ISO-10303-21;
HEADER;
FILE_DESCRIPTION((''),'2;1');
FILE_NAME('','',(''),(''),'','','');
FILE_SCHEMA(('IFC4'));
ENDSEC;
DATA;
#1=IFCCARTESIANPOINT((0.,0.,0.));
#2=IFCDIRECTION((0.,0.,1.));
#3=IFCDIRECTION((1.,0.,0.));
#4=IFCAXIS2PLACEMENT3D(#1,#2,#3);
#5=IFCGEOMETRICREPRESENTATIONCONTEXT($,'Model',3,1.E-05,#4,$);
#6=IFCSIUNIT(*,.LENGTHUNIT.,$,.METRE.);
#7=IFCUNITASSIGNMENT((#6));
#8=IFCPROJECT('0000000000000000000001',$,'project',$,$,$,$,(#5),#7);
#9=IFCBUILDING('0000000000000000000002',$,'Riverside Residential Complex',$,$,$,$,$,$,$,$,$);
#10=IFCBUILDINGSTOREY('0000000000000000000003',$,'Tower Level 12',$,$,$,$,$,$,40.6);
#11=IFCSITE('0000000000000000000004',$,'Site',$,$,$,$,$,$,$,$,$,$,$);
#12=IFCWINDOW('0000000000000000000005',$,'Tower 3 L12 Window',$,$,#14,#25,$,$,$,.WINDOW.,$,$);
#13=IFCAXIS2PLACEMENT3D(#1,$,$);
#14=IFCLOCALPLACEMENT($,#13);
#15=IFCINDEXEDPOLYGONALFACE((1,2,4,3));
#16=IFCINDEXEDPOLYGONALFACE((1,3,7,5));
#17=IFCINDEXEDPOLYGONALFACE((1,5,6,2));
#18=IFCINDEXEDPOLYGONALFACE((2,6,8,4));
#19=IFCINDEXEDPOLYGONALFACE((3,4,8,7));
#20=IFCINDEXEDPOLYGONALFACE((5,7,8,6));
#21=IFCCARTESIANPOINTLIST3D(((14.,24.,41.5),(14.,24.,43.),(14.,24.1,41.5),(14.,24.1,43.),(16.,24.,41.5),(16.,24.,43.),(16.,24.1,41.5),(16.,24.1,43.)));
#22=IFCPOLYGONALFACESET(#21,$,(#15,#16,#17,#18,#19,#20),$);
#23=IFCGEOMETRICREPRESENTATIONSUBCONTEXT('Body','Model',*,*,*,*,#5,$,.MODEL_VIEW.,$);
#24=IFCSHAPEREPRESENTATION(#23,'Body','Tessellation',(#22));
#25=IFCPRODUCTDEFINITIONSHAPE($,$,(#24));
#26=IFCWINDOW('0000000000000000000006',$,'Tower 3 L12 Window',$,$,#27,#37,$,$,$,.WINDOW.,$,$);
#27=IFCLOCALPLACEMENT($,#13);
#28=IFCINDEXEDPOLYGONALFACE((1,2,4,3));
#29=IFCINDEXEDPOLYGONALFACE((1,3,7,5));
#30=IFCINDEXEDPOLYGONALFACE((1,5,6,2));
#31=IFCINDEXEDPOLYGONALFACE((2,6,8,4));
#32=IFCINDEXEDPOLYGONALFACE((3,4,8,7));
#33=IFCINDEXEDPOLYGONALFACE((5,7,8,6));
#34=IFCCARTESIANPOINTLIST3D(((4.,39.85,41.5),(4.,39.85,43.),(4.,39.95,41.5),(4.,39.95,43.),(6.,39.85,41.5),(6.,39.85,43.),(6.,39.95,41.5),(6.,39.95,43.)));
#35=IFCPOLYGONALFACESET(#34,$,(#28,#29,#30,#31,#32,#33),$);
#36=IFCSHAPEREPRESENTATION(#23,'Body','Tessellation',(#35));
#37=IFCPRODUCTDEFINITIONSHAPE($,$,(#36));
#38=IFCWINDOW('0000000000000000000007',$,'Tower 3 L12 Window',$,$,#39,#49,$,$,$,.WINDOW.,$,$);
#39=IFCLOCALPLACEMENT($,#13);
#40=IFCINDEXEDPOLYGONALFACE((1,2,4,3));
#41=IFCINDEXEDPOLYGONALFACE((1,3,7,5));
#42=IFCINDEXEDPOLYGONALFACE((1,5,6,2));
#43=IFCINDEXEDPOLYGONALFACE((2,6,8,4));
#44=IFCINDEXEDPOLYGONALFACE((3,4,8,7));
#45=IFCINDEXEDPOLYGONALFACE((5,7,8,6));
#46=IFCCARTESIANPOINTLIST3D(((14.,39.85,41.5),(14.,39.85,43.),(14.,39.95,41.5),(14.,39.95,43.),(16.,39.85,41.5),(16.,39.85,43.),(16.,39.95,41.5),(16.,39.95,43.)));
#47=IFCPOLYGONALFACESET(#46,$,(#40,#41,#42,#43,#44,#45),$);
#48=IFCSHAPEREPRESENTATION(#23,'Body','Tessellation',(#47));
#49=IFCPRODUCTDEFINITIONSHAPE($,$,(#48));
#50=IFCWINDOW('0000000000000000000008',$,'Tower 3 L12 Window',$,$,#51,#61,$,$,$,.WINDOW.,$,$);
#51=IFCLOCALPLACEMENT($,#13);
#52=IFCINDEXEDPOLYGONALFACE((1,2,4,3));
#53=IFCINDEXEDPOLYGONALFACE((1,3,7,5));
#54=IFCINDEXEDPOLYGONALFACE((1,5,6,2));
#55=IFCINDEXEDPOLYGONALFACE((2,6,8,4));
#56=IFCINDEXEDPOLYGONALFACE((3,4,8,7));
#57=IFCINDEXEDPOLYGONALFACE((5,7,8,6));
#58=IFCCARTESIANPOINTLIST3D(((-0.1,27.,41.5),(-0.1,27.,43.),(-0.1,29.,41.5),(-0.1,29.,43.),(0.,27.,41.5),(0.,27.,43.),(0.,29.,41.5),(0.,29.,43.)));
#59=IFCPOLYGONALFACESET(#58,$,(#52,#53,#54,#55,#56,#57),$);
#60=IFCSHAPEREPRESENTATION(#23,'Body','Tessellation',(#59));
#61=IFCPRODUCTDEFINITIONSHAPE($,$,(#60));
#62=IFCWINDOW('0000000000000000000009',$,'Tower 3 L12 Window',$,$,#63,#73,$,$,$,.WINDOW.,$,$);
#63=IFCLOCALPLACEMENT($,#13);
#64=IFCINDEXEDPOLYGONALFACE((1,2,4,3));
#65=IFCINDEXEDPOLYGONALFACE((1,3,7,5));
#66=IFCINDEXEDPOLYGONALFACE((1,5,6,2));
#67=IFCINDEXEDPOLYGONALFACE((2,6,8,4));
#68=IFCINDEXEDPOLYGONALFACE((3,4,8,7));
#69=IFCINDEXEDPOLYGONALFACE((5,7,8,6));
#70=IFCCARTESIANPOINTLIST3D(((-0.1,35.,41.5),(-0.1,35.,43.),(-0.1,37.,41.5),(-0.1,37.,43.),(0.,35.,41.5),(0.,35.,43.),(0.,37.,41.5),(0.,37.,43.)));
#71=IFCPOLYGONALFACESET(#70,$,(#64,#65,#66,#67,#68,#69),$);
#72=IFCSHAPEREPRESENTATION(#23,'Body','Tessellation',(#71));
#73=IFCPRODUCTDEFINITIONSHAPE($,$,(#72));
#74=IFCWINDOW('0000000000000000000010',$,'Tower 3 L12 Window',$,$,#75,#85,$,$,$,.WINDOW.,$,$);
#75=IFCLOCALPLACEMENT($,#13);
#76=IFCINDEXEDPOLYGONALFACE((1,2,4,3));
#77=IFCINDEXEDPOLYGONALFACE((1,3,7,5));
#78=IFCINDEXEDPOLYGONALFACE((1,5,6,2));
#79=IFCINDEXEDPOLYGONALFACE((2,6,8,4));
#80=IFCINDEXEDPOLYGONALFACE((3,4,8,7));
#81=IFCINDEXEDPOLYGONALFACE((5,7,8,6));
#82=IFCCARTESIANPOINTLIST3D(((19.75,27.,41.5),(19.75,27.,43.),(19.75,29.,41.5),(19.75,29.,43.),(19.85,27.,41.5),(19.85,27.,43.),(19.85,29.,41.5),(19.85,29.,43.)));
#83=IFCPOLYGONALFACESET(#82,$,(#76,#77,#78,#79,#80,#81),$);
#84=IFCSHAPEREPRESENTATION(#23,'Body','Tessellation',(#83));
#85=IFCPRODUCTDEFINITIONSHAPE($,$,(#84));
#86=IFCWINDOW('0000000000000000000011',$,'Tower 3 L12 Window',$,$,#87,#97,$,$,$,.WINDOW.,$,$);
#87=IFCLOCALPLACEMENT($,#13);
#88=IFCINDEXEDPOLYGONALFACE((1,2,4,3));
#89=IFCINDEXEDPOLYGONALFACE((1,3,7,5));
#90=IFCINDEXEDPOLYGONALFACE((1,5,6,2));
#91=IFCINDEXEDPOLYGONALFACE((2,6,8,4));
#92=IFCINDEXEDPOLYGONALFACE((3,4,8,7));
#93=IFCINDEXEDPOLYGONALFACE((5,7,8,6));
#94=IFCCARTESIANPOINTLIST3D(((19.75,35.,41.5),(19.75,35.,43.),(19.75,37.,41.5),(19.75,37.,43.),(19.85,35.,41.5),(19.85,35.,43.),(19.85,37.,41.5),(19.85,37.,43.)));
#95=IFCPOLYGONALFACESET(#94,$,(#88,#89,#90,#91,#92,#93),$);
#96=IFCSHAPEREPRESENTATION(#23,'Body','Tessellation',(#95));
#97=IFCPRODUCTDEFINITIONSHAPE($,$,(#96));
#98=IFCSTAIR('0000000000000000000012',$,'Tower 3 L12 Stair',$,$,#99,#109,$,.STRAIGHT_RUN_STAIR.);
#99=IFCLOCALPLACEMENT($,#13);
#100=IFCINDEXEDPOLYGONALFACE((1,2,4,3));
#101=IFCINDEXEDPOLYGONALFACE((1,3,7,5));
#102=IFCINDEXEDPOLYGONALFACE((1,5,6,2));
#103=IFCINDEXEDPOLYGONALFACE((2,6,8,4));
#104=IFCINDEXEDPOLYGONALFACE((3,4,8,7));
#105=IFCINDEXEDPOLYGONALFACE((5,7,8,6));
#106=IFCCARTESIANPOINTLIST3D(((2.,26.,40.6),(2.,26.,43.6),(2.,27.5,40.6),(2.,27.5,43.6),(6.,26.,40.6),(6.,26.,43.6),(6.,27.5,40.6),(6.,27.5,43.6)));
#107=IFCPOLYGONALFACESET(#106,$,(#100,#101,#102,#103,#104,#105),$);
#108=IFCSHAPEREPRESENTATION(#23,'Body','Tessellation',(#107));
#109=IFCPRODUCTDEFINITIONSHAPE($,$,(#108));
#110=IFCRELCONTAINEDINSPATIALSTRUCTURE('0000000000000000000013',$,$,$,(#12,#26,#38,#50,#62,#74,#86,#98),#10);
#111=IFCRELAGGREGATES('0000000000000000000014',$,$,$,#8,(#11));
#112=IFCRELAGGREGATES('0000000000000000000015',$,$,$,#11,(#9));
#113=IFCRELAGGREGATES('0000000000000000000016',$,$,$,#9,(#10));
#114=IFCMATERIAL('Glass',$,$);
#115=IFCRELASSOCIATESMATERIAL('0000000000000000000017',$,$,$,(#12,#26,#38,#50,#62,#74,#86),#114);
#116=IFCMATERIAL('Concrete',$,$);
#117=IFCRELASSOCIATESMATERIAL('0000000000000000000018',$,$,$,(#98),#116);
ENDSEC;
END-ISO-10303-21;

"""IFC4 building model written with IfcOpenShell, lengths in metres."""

from ifc_helpers import new_model, si_unit, frame, origin_with_axes, place, context, subcontext, project, spatial, line, indexed_curve, outline, extrude, material, element, save


model = new_model("IFC4")

# Units and contexts
model_context = context("Model", 3, precision=1e-05, world=origin_with_axes())
body_context = subcontext(model_context, "Body", "Model", "MODEL_VIEW")
ifc_project = project(units=[si_unit("LENGTHUNIT", "METRE")], contexts=[model_context])

# Site, building, storey
site = spatial("IfcSite", under=ifc_project, Name="Site")
building = spatial("IfcBuilding", under=site, Name="Riverside Residential Complex")
storey = spatial("IfcBuildingStorey", under=building, Name="Tower Level 12", Elevation=40.6)

# Shared definitions
ifc_material_1 = material(Name="Concrete")

# Windows
ifc_material_2 = material(Name="Glass")
for number, where, z_axis, x_axis, name in (
    (1, (14.0, 24.0, 41.5), (0.0, 0.0, 1.0), (1.0, 0.0, 0.0), "Tower 3 L12 Window"),
    (2, (4.0, 39.85, 41.5), (0.0, 0.0, 1.0), (1.0, 0.0, 0.0), "Tower 3 L12 Window"),
    (3, (14.0, 39.85, 41.5), (0.0, 0.0, 1.0), (1.0, 0.0, 0.0), "Tower 3 L12 Window"),
    (4, (0.0, 27.0, 41.5), (0.0, 0.0, 1.0), (0.0, 1.0, 0.0), "Tower 3 L12 Window"),
    (5, (0.0, 35.0, 41.5), (0.0, 0.0, 1.0), (0.0, 1.0, 0.0), "Tower 3 L12 Window"),
    (6, (19.85, 27.0, 41.5), (0.0, 0.0, 1.0), (0.0, 1.0, 0.0), "Tower 3 L12 Window"),
    (7, (19.85, 35.0, 41.5), (0.0, 0.0, 1.0), (0.0, 1.0, 0.0), "Tower 3 L12 Window"),
):
    element("IfcWindow", number, at=place(None, frame(where, z_axis=z_axis, x_axis=x_axis)), inside=storey, material=ifc_material_2, Name=name, PredefinedType="WINDOW", context=body_context, shape_type="SweptSolid", body=[
        extrude(outline(indexed_curve([(0.0, 0.0), (2.0, 0.0), (2.0, 0.1), (0.0, 0.1)], segments=[line(1, 2, 3, 4, 1)])), origin_with_axes(), (0.0, 0.0, 1.0), 1.5),
    ])

# Stair
stair_placement = place(None, frame((2.0, 26.0, 40.6), z_axis=(0.0, 0.0, 1.0), x_axis=(1.0, 0.0, 0.0)))
element("IfcStair", 8, at=stair_placement, inside=storey, material=ifc_material_1, Name="Tower 3 L12 Stair", PredefinedType="STRAIGHT_RUN_STAIR", context=body_context, shape_type="SweptSolid", body=[
    extrude(outline(indexed_curve([(0.0, 0.0), (4.0, 0.0), (4.0, 1.5), (0.0, 1.5)], segments=[line(1, 2, 3, 4, 1)])), origin_with_axes(), (0.0, 0.0, 1.0), 3.0),
])

save(model, "model.ifc")
